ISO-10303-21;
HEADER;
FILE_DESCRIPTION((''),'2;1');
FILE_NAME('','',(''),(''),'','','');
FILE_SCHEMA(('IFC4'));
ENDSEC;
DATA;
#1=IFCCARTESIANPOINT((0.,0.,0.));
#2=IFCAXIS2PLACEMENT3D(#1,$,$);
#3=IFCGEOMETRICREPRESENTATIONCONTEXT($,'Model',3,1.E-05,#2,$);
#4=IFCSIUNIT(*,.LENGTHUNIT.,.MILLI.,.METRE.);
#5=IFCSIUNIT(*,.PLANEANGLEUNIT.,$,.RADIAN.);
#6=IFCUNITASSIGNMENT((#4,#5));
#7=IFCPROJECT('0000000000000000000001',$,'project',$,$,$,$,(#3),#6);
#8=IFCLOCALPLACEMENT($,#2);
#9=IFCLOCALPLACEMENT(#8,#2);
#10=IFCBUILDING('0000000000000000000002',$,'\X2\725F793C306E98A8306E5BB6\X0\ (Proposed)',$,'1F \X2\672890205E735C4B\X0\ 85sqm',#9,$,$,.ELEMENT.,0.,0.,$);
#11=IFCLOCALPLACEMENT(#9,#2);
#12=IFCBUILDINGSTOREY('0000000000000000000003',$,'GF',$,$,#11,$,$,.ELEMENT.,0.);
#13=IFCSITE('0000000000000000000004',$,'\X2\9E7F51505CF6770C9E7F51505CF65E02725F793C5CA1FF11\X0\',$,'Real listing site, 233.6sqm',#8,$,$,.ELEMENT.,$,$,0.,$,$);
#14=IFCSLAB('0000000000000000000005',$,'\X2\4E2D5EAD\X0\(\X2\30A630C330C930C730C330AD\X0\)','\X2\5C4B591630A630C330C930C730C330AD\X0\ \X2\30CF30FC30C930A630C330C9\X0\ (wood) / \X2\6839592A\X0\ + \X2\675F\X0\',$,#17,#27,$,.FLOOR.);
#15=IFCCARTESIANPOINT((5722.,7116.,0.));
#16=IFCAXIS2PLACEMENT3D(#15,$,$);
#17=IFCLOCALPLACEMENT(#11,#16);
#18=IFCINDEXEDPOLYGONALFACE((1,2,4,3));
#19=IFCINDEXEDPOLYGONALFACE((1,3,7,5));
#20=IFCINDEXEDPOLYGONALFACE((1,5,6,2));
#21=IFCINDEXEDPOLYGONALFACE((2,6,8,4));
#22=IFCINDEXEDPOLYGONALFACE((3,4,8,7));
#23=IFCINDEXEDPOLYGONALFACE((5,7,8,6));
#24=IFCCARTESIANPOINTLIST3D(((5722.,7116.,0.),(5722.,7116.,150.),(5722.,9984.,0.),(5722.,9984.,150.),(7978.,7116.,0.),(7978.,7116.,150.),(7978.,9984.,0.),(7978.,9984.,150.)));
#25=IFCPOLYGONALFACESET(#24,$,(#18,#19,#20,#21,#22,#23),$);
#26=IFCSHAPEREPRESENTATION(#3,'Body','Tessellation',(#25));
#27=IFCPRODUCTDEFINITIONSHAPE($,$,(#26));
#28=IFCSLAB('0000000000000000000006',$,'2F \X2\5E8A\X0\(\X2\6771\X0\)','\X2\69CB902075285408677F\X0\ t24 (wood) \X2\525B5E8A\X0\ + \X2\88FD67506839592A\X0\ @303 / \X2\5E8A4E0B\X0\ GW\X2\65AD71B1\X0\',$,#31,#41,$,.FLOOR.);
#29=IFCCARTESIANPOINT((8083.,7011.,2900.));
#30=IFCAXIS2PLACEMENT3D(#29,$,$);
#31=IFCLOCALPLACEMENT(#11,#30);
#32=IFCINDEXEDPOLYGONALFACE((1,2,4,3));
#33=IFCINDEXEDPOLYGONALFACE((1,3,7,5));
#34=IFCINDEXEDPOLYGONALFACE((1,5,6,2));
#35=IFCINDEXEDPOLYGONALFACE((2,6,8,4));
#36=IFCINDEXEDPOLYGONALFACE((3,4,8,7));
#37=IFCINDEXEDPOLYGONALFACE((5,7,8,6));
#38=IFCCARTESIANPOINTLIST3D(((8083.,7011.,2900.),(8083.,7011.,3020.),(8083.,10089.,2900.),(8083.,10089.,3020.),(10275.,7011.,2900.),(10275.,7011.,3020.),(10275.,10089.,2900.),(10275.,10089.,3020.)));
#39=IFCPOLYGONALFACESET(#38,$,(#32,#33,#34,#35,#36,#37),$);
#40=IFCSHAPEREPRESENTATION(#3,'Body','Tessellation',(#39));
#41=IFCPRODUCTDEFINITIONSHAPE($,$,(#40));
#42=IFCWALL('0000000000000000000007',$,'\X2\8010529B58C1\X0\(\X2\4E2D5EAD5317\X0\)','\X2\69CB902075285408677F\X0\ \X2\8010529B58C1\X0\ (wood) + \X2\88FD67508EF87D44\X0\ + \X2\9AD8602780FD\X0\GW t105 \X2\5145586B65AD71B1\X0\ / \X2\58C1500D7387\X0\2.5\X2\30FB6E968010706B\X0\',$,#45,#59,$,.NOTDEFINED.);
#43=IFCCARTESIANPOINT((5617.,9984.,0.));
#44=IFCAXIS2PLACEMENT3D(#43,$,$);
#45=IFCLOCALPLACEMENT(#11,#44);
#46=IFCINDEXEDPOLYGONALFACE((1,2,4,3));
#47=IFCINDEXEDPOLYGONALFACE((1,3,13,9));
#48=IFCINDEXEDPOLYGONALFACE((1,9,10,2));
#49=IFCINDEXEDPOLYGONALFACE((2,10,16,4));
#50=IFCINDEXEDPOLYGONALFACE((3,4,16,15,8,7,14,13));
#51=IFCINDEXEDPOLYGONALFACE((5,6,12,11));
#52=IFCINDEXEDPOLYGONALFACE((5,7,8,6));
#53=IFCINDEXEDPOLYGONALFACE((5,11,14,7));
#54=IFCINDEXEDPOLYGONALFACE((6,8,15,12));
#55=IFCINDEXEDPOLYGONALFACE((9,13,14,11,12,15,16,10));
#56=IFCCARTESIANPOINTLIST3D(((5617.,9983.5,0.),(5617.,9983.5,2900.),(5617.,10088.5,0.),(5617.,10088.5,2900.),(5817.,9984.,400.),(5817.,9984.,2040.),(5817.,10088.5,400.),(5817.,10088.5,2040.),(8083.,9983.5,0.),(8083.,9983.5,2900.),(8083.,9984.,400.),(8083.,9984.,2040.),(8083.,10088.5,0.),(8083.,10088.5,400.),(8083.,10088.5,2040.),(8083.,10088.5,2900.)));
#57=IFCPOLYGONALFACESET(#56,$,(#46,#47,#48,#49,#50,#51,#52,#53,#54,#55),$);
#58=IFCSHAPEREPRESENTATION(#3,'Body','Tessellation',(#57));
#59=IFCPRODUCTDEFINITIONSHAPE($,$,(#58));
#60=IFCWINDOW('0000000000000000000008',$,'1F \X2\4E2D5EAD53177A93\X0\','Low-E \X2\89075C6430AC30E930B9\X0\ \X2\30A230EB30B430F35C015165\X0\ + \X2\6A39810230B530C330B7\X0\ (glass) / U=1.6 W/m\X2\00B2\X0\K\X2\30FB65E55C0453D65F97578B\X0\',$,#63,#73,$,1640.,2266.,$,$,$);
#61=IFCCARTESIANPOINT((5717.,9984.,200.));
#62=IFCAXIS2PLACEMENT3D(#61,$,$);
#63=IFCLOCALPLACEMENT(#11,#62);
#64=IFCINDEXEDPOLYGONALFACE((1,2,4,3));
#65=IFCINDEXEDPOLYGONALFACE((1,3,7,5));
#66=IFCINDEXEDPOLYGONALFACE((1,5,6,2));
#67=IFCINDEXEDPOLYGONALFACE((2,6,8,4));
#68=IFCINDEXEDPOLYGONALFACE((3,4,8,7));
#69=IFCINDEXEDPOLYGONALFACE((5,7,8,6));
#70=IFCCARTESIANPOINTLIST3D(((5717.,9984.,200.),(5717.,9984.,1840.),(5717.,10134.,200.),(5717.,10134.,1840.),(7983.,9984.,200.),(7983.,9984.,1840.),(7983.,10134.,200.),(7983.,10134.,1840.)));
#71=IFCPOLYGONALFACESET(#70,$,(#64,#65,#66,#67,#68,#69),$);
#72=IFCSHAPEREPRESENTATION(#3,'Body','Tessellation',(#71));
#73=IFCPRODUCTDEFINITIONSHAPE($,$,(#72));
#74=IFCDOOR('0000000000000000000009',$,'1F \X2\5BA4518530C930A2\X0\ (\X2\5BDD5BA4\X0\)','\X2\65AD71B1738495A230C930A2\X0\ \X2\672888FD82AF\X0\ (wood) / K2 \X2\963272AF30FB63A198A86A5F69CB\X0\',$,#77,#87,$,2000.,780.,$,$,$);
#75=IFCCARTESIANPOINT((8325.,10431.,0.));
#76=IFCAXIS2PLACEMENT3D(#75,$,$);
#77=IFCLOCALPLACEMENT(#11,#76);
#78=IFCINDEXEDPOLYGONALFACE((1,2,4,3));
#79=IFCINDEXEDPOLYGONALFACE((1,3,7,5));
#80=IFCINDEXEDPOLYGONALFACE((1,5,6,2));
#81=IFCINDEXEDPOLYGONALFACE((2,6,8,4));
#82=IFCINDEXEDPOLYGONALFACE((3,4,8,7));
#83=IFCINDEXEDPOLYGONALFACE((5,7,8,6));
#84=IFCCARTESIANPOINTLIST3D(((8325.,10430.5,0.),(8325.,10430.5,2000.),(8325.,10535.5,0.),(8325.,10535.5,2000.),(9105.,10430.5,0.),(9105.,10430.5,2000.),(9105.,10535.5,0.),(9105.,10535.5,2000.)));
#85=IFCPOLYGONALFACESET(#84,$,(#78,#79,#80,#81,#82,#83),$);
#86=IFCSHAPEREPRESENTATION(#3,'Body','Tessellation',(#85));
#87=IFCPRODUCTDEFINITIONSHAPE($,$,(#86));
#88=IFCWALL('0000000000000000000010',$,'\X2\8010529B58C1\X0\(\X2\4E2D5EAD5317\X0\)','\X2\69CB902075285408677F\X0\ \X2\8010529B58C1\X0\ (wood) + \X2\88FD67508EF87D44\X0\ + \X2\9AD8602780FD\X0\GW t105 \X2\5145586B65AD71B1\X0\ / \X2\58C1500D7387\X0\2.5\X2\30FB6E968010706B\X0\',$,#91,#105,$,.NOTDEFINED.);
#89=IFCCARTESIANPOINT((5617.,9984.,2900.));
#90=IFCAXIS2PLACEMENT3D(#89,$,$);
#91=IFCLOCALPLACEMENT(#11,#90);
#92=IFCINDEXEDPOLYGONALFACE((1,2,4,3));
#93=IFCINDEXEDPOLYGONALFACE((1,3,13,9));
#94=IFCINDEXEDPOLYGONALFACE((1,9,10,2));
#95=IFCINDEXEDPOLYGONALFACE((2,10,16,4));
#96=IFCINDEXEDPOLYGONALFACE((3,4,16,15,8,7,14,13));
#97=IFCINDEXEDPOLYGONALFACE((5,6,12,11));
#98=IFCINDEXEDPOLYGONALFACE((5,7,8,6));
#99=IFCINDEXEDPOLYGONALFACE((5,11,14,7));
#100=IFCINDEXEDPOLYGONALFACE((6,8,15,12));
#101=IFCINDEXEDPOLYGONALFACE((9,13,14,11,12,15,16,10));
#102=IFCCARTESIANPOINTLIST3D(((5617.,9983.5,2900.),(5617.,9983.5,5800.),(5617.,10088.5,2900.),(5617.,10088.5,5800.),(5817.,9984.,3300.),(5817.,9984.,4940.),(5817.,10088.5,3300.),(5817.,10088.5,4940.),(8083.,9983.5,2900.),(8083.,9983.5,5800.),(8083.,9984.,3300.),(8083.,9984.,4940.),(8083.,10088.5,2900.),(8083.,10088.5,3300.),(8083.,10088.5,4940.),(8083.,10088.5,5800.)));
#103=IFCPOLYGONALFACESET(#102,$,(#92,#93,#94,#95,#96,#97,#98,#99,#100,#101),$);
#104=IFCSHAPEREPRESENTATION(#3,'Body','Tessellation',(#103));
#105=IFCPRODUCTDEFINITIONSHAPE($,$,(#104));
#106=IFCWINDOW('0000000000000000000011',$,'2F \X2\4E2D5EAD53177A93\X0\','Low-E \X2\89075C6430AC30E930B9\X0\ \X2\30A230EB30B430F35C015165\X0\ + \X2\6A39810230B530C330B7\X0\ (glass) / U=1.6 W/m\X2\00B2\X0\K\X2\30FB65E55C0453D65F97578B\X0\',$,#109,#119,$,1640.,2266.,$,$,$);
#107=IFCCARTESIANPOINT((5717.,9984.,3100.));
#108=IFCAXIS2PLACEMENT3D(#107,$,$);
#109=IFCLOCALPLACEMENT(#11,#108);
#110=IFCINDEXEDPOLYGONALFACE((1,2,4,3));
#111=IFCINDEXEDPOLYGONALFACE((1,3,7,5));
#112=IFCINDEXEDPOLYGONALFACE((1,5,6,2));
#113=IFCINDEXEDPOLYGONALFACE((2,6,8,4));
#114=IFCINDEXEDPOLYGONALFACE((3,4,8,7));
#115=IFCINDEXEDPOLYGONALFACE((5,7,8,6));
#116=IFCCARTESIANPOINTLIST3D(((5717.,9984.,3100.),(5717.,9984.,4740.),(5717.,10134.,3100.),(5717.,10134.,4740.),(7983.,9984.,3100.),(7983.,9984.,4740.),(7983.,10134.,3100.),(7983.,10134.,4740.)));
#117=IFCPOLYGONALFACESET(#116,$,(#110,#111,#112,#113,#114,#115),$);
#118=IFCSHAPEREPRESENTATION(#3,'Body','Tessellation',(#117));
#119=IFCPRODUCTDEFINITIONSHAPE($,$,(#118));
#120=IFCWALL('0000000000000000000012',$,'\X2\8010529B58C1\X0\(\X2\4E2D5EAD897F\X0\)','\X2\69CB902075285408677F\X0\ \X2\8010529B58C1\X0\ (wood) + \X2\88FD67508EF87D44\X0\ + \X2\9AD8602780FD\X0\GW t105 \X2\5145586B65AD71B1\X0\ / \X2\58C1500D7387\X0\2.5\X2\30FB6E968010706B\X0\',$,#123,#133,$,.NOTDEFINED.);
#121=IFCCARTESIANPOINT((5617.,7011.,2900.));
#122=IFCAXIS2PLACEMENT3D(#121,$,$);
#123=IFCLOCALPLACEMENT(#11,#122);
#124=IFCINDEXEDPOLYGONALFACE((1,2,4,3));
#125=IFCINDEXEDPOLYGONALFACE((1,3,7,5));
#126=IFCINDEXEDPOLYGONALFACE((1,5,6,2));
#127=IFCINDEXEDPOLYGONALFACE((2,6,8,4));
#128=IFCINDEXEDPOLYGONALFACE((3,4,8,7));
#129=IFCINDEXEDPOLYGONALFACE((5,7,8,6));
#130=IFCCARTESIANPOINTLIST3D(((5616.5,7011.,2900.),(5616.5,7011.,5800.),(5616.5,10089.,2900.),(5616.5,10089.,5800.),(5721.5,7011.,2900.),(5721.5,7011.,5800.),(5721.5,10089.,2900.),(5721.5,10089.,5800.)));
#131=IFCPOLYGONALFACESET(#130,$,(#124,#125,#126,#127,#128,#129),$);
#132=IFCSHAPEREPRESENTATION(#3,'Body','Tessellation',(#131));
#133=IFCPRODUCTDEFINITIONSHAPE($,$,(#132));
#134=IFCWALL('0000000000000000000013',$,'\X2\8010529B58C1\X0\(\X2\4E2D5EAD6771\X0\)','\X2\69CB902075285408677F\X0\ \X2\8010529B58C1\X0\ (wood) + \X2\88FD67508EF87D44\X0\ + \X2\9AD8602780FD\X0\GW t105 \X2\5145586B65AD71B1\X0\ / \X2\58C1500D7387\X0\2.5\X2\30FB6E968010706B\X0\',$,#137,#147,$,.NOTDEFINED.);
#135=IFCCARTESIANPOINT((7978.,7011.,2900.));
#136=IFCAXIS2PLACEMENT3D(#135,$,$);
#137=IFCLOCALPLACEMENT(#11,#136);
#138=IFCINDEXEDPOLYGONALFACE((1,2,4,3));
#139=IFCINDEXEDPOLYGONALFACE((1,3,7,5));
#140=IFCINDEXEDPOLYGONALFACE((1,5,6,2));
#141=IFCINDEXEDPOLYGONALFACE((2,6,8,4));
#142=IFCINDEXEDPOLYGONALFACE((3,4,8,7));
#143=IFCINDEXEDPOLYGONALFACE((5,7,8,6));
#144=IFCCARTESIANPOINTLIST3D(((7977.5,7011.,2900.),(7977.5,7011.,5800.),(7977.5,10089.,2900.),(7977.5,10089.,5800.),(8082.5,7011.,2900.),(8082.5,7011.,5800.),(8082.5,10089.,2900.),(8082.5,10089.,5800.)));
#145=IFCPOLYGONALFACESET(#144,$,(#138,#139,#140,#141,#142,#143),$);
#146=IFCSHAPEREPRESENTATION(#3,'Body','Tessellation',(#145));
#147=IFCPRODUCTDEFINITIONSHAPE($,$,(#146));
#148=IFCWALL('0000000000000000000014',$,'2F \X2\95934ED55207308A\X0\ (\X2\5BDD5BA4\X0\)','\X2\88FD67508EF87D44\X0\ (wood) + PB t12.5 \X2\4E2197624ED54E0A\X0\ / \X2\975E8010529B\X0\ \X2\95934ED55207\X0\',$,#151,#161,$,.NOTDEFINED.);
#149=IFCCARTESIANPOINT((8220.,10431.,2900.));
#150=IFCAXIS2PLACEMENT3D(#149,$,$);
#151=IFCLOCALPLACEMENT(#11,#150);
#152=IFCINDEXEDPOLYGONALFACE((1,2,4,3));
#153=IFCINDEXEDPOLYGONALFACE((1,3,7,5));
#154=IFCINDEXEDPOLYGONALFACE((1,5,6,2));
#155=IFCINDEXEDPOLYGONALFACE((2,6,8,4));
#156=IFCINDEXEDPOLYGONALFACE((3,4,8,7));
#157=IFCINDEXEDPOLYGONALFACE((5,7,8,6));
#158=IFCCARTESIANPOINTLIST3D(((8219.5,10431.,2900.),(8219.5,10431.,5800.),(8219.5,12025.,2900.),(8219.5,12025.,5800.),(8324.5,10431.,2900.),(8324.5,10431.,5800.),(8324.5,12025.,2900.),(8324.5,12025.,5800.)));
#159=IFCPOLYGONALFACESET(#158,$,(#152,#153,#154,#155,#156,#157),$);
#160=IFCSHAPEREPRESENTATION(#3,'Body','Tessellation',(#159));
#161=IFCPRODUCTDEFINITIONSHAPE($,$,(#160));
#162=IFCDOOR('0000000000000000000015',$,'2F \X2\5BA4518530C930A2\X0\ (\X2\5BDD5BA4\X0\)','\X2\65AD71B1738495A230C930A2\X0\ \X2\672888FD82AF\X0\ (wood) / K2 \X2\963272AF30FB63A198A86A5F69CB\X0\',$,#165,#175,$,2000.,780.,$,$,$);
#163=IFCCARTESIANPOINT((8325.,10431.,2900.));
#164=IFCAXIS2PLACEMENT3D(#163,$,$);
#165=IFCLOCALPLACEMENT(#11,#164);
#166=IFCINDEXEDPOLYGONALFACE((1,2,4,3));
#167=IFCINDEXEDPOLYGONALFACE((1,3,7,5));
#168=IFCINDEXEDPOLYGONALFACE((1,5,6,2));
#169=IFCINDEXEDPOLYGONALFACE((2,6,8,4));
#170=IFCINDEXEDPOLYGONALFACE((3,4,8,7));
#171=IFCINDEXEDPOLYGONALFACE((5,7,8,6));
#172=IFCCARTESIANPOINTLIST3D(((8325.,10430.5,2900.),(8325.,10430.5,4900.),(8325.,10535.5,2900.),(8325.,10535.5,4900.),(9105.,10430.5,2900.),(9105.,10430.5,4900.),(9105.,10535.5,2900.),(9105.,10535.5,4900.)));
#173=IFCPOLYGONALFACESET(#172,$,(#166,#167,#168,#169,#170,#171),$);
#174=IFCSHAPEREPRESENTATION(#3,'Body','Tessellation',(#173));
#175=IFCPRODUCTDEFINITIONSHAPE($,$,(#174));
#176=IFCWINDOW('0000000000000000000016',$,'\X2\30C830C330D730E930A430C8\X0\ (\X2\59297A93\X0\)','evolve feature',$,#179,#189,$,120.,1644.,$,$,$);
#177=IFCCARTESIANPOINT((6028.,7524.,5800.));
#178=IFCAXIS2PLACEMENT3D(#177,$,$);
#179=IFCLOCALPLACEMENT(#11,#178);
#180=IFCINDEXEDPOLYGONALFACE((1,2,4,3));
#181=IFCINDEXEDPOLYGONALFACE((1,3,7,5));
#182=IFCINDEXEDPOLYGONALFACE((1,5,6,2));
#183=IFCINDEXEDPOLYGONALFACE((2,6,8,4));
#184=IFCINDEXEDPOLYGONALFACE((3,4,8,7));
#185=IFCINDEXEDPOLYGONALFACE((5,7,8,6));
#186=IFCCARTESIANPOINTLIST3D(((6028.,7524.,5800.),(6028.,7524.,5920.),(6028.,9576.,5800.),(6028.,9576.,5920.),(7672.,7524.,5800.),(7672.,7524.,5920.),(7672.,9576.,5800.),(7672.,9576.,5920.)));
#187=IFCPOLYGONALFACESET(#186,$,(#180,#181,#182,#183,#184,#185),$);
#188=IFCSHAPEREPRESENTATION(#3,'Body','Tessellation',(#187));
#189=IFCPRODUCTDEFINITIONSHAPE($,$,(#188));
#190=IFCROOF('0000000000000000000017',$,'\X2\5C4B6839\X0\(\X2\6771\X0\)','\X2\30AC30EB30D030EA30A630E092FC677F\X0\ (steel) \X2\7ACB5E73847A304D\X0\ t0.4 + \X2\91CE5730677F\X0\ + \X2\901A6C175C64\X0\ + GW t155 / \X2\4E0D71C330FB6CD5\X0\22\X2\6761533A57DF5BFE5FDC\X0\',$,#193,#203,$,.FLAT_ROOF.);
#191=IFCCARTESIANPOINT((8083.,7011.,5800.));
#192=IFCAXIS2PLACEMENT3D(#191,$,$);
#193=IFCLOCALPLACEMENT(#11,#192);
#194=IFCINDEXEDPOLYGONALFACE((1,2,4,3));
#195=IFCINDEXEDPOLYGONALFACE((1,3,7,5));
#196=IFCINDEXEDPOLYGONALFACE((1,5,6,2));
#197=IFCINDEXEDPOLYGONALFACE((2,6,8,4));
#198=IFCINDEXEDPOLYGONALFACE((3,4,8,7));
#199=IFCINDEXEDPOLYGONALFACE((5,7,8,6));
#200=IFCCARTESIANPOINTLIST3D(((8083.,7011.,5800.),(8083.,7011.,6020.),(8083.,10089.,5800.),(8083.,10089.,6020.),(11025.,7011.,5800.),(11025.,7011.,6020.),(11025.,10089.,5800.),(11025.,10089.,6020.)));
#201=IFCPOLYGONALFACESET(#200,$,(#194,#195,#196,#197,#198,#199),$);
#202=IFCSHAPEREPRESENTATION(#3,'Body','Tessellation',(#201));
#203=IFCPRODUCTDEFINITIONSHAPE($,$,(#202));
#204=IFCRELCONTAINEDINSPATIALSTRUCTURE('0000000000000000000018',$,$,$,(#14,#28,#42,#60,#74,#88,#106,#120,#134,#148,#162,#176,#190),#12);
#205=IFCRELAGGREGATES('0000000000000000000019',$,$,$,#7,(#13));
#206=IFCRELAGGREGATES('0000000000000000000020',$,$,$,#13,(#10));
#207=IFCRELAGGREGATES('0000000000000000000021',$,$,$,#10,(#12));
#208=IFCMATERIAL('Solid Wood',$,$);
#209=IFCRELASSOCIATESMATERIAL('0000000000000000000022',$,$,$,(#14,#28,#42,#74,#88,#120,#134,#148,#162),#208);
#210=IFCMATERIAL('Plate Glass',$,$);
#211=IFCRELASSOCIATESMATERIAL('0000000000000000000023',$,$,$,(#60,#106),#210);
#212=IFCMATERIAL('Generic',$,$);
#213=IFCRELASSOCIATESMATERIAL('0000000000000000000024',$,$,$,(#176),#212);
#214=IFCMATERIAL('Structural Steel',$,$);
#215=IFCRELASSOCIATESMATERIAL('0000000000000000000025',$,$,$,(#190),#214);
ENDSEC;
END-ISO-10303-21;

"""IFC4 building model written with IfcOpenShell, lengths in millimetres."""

from ifc_helpers import new_model, si_unit, frame, frame_2d, origin, place, context, project, spatial, rectangle, extrude, material, element, fill, save


model = new_model("IFC4")

# Units and contexts
model_context = context("Model", 3, precision=1e-05, world=origin())
ifc_project = project(units=[si_unit("LENGTHUNIT", "METRE", prefix="MILLI"), si_unit("PLANEANGLEUNIT", "RADIAN")], contexts=[model_context])

# Site, building, storey
site_placement = place(None, origin())
site = spatial("IfcSite", under=ifc_project, at=site_placement, Name="鹿児島県鹿児島市牟礼岡１", ObjectType="Real listing site, 233.6sqm", CompositionType="ELEMENT", RefElevation=0.0)
building_placement = place(site_placement, origin())
building = spatial("IfcBuilding", under=site, at=building_placement, Name="牟礼の風の家 (Proposed)", ObjectType="1F 木造平屋 85sqm", CompositionType="ELEMENT", ElevationOfRefHeight=0.0, ElevationOfTerrain=0.0)
storey_placement = place(building_placement, origin())
storey = spatial("IfcBuildingStorey", under=building, at=storey_placement, Name="GF", CompositionType="ELEMENT", Elevation=0.0)

# Slabs
ifc_material_1 = material(Name="Solid Wood")
slab_1_placement = place(storey_placement, frame((5722.0, 7116.0, 0.0)))
element("IfcSlab", 1, at=slab_1_placement, inside=storey, material=ifc_material_1, Name="中庭(ウッドデッキ)", Description="屋外ウッドデッキ ハードウッド (wood) / 根太 + 束", PredefinedType="FLOOR", context=model_context, shape_type="SweptSolid", body=[
    extrude(rectangle(XDim=2256.0, YDim=2868.0, at=frame_2d((1128.0, 1434.0))), frame((5722.0, 7116.0, 0.0)), (0.0, 0.0, 1.0), 150.0),
])
slab_2_placement = place(storey_placement, frame((8083.0, 7011.0, 2900.0)))
element("IfcSlab", 2, at=slab_2_placement, inside=storey, material=ifc_material_1, Name="2F 床(東)", Description="構造用合板 t24 (wood) 剛床 + 製材根太 @303 / 床下 GW断熱", PredefinedType="FLOOR", context=model_context, shape_type="SweptSolid", body=[
    extrude(rectangle(XDim=2192.0, YDim=3078.0, at=frame_2d((1096.0, 1539.0))), frame((8083.0, 7011.0, 2900.0)), (0.0, 0.0, 1.0), 120.0),
])

# Wall, opening, window
wall_1_placement = place(storey_placement, frame((5617.0, 9984.0, 0.0)))
wall_1 = element("IfcWall", 3, at=wall_1_placement, inside=storey, material=ifc_material_1, Name="耐力壁(中庭北)", Description="構造用合板 耐力壁 (wood) + 製材軸組 + 高性能GW t105 充填断熱 / 壁倍率2.5・準耐火", PredefinedType="NOTDEFINED", context=model_context, shape_type="SweptSolid", body=[
    extrude(rectangle(XDim=2466.0, YDim=105.0, at=frame_2d((1233.0, 52.0))), frame((5617.0, 9984.0, 0.0)), (0.0, 0.0, 1.0), 2900.0),
])
opening_1_placement = place(storey_placement, frame((5717.0, 9984.0, 200.0)))
opening_1 = element("IfcOpeningElement", 4, at=opening_1_placement, cuts=wall_1, PredefinedType="NOTDEFINED", context=model_context, shape_type="SweptSolid", body=[
    extrude(rectangle(XDim=2266.0, YDim=150.0, at=frame_2d((1133.0, 75.0))), frame((5717.0, 9984.0, 200.0)), (0.0, 0.0, 1.0), 1640.0),
])
ifc_material_2 = material(Name="Plate Glass")
window_1_placement = place(storey_placement, frame((5717.0, 9984.0, 200.0)))
window_1 = element("IfcWindow", 5, at=window_1_placement, inside=storey, material=ifc_material_2, Name="1F 中庭北窓", Description="Low-E 複層ガラス アルゴン封入 + 樹脂サッシ (glass) / U=1.6 W/m²K・日射取得型", OverallHeight=1640.0, OverallWidth=2266.0, context=model_context, shape_type="SweptSolid", body=[
    extrude(rectangle(XDim=2266.0, YDim=150.0, at=frame_2d((1133.0, 75.0))), frame((5717.0, 9984.0, 200.0)), (0.0, 0.0, 1.0), 1640.0),
])
fill(opening_1, window_1)

# Door
door_1_placement = place(storey_placement, frame((8325.0, 10431.0, 0.0)))
element("IfcDoor", 6, at=door_1_placement, inside=storey, material=ifc_material_1, Name="1F 室内ドア (寝室)", Description="断熱玄関ドア 木製芯 (wood) / K2 防犯・採風機構", OverallHeight=2000.0, OverallWidth=780.0, context=model_context, shape_type="SweptSolid", body=[
    extrude(rectangle(XDim=780.0, YDim=105.0, at=frame_2d((390.0, 52.0))), frame((8325.0, 10431.0, 0.0)), (0.0, 0.0, 1.0), 2000.0),
])

# Wall, opening, window
wall_2_placement = place(storey_placement, frame((5617.0, 9984.0, 2900.0)))
wall_2 = element("IfcWall", 7, at=wall_2_placement, inside=storey, material=ifc_material_1, Name="耐力壁(中庭北)", Description="構造用合板 耐力壁 (wood) + 製材軸組 + 高性能GW t105 充填断熱 / 壁倍率2.5・準耐火", PredefinedType="NOTDEFINED", context=model_context, shape_type="SweptSolid", body=[
    extrude(rectangle(XDim=2466.0, YDim=105.0, at=frame_2d((1233.0, 52.0))), frame((5617.0, 9984.0, 2900.0)), (0.0, 0.0, 1.0), 2900.0),
])
opening_2_placement = place(storey_placement, frame((5717.0, 9984.0, 3100.0)))
opening_2 = element("IfcOpeningElement", 8, at=opening_2_placement, cuts=wall_2, PredefinedType="NOTDEFINED", context=model_context, shape_type="SweptSolid", body=[
    extrude(rectangle(XDim=2266.0, YDim=150.0, at=frame_2d((1133.0, 75.0))), frame((5717.0, 9984.0, 3100.0)), (0.0, 0.0, 1.0), 1640.0),
])
window_2_placement = place(storey_placement, frame((5717.0, 9984.0, 3100.0)))
window_2 = element("IfcWindow", 9, at=window_2_placement, inside=storey, material=ifc_material_2, Name="2F 中庭北窓", Description="Low-E 複層ガラス アルゴン封入 + 樹脂サッシ (glass) / U=1.6 W/m²K・日射取得型", OverallHeight=1640.0, OverallWidth=2266.0, context=model_context, shape_type="SweptSolid", body=[
    extrude(rectangle(XDim=2266.0, YDim=150.0, at=frame_2d((1133.0, 75.0))), frame((5717.0, 9984.0, 3100.0)), (0.0, 0.0, 1.0), 1640.0),
])
fill(opening_2, window_2)

# Walls
wall_3_placement = place(storey_placement, frame((5617.0, 7011.0, 2900.0)))
element("IfcWall", 10, at=wall_3_placement, inside=storey, material=ifc_material_1, Name="耐力壁(中庭西)", Description="構造用合板 耐力壁 (wood) + 製材軸組 + 高性能GW t105 充填断熱 / 壁倍率2.5・準耐火", PredefinedType="NOTDEFINED", context=model_context, shape_type="SweptSolid", body=[
    extrude(rectangle(XDim=105.0, YDim=3078.0, at=frame_2d((52.0, 1539.0))), frame((5617.0, 7011.0, 2900.0)), (0.0, 0.0, 1.0), 2900.0),
])
wall_4_placement = place(storey_placement, frame((7978.0, 7011.0, 2900.0)))
element("IfcWall", 11, at=wall_4_placement, inside=storey, material=ifc_material_1, Name="耐力壁(中庭東)", Description="構造用合板 耐力壁 (wood) + 製材軸組 + 高性能GW t105 充填断熱 / 壁倍率2.5・準耐火", PredefinedType="NOTDEFINED", context=model_context, shape_type="SweptSolid", body=[
    extrude(rectangle(XDim=105.0, YDim=3078.0, at=frame_2d((52.0, 1539.0))), frame((7978.0, 7011.0, 2900.0)), (0.0, 0.0, 1.0), 2900.0),
])
wall_5_placement = place(storey_placement, frame((8220.0, 10431.0, 2900.0)))
element("IfcWall", 12, at=wall_5_placement, inside=storey, material=ifc_material_1, Name="2F 間仕切り (寝室)", Description="製材軸組 (wood) + PB t12.5 両面仕上 / 非耐力 間仕切", PredefinedType="NOTDEFINED", context=model_context, shape_type="SweptSolid", body=[
    extrude(rectangle(XDim=105.0, YDim=1594.0, at=frame_2d((52.0, 797.0))), frame((8220.0, 10431.0, 2900.0)), (0.0, 0.0, 1.0), 2900.0),
])

# Door
door_2_placement = place(storey_placement, frame((8325.0, 10431.0, 2900.0)))
element("IfcDoor", 13, at=door_2_placement, inside=storey, material=ifc_material_1, Name="2F 室内ドア (寝室)", Description="断熱玄関ドア 木製芯 (wood) / K2 防犯・採風機構", OverallHeight=2000.0, OverallWidth=780.0, context=model_context, shape_type="SweptSolid", body=[
    extrude(rectangle(XDim=780.0, YDim=105.0, at=frame_2d((390.0, 52.0))), frame((8325.0, 10431.0, 2900.0)), (0.0, 0.0, 1.0), 2000.0),
])

# Window
ifc_material_3 = material(Name="Generic")
window_3_placement = place(storey_placement, frame((6028.0, 7524.0, 5800.0)))
element("IfcWindow", 14, at=window_3_placement, inside=storey, material=ifc_material_3, Name="トップライト (天窓)", Description="evolve feature", OverallHeight=120.0, OverallWidth=1644.0, context=model_context, shape_type="SweptSolid", body=[
    extrude(rectangle(XDim=1644.0, YDim=2052.0, at=frame_2d((822.0, 1026.0))), frame((6028.0, 7524.0, 5800.0)), (0.0, 0.0, 1.0), 120.0),
])

# Roof
ifc_material_4 = material(Name="Structural Steel")
roof_placement = place(storey_placement, frame((8083.0, 7011.0, 5800.0)))
element("IfcRoof", 15, at=roof_placement, inside=storey, material=ifc_material_4, Name="屋根(東)", Description="ガルバリウム鋼板 (steel) 立平葺き t0.4 + 野地板 + 通気層 + GW t155 / 不燃・法22条区域対応", PredefinedType="FLAT_ROOF", context=model_context, shape_type="SweptSolid", body=[
    extrude(rectangle(XDim=2942.0, YDim=3078.0, at=frame_2d((1471.0, 1539.0))), frame((8083.0, 7011.0, 5800.0)), (0.0, 0.0, 1.0), 220.0),
])

save(model, "model.ifc")
